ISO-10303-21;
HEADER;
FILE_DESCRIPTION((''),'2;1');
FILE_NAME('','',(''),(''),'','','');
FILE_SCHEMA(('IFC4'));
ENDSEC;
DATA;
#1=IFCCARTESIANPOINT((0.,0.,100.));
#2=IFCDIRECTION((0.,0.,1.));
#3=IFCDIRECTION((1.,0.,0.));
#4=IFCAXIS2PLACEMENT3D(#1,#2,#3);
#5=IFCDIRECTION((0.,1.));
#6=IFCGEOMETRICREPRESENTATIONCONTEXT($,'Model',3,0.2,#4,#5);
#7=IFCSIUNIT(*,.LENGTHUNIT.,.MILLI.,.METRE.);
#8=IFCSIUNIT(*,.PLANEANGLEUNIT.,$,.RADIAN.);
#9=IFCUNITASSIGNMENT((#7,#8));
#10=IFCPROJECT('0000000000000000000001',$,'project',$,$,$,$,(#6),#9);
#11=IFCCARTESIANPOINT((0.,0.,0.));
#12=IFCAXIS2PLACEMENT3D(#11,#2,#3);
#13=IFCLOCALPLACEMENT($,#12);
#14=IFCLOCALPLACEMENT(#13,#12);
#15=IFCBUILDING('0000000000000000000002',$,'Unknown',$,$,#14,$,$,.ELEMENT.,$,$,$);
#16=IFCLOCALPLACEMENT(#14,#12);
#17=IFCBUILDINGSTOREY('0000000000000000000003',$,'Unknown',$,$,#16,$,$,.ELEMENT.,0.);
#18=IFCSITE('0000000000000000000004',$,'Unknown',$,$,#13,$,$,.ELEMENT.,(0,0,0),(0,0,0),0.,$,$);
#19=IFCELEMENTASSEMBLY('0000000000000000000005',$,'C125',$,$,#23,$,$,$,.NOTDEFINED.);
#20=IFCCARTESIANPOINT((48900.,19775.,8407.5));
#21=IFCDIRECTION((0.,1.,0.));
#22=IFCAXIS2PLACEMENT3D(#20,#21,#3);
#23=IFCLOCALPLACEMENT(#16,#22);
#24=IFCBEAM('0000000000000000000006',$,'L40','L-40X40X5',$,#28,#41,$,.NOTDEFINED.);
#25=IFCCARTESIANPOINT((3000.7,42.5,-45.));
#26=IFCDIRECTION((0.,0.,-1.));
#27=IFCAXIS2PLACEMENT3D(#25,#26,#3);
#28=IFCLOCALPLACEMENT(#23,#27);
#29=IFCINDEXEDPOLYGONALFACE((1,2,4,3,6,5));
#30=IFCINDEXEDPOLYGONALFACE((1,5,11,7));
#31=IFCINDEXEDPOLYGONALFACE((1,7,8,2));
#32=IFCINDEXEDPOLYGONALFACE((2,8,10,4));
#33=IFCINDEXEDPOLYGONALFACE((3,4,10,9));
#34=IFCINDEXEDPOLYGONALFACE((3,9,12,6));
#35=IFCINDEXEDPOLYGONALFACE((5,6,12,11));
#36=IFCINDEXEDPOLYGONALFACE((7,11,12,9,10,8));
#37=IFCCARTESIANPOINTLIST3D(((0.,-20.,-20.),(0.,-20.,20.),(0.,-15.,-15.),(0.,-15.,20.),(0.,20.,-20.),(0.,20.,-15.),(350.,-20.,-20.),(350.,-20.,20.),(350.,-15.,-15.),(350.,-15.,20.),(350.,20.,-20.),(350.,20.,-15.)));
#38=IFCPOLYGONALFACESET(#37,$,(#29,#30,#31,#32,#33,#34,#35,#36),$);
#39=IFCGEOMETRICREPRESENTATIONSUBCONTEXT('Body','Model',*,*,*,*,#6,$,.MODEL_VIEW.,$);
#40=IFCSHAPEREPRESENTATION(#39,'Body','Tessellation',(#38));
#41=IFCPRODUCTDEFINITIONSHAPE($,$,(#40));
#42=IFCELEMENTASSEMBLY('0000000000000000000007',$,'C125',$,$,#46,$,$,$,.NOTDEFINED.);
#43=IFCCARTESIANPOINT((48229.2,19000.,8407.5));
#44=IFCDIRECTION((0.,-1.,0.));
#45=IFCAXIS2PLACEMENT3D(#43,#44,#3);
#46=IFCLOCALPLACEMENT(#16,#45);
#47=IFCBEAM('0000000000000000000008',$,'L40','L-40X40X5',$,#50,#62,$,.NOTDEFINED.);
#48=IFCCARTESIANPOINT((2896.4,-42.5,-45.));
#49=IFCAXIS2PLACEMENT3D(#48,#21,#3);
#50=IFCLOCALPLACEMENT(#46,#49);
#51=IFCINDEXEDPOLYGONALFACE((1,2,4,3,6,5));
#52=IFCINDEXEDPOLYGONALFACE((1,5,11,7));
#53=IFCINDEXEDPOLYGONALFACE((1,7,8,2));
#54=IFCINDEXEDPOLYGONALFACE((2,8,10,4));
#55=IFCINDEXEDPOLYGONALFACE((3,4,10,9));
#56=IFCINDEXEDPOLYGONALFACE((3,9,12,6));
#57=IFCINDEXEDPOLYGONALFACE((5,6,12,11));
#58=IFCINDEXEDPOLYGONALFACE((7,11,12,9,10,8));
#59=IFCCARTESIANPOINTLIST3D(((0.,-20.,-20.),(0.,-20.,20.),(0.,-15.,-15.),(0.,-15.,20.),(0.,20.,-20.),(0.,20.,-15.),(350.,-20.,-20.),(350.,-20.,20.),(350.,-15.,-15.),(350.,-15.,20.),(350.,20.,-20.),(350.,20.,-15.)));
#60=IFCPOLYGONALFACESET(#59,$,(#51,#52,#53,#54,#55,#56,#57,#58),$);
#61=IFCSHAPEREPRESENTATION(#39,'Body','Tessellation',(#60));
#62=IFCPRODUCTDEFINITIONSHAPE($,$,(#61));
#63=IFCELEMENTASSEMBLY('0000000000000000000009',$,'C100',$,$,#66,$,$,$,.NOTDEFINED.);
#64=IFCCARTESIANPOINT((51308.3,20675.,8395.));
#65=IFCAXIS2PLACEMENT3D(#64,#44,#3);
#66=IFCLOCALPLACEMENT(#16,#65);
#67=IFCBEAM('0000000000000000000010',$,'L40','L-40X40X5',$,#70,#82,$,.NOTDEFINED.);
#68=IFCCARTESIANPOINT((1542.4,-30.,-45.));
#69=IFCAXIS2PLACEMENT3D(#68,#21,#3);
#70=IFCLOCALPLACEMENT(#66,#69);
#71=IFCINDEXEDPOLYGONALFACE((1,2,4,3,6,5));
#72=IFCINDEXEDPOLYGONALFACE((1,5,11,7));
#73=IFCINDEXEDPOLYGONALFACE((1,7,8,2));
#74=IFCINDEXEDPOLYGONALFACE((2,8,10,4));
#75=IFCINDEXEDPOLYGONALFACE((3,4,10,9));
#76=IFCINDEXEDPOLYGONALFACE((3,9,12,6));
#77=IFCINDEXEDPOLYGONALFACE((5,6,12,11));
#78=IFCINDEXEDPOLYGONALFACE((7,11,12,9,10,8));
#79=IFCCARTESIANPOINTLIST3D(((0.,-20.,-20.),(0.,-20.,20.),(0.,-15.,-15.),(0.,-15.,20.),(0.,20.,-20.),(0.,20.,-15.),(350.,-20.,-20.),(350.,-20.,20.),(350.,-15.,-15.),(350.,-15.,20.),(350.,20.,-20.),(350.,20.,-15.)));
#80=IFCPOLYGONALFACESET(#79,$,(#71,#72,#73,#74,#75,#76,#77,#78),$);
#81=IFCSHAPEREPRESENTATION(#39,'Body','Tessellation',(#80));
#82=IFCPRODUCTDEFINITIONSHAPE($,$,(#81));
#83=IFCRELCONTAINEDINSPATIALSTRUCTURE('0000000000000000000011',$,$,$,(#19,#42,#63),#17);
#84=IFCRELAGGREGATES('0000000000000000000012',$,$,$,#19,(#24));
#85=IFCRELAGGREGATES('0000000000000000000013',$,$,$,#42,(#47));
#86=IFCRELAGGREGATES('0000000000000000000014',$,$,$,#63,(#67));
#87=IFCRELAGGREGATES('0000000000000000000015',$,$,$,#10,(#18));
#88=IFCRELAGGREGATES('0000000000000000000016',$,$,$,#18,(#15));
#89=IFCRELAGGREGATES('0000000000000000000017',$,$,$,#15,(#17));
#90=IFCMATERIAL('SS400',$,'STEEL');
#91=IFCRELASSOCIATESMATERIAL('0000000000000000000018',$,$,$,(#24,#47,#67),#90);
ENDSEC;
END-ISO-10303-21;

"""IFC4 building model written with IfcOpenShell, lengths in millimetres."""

from ifc_helpers import new_model, si_unit, direction, frame, origin_with_axes, place, context, subcontext, project, spatial, line, indexed_curve, outline, extrude, material, element, aggregate, save


model = new_model("IFC4")

# Units and contexts
model_context = context("Model", 3, precision=0.2, world=frame((0.0, 0.0, 100.0), z_axis=(0.0, 0.0, 1.0), x_axis=(1.0, 0.0, 0.0)), true_north=direction((0.0, 1.0)))
body_context = subcontext(model_context, "Body", "Model", "MODEL_VIEW")
ifc_project = project(units=[si_unit("LENGTHUNIT", "METRE", prefix="MILLI"), si_unit("PLANEANGLEUNIT", "RADIAN")], contexts=[model_context])

# Site, building, storey
site_placement = place(None, origin_with_axes())
site = spatial("IfcSite", under=ifc_project, at=site_placement, Name="Unknown", CompositionType="ELEMENT", RefLatitude=(0, 0, 0), RefLongitude=(0, 0, 0), RefElevation=0.0)
building_placement = place(site_placement, origin_with_axes())
building = spatial("IfcBuilding", under=site, at=building_placement, Name="Unknown", CompositionType="ELEMENT")
storey_placement = place(building_placement, origin_with_axes())
storey = spatial("IfcBuildingStorey", under=building, at=storey_placement, Name="Unknown", CompositionType="ELEMENT", Elevation=0.0)

# Shared definitions
ifc_material_1 = material(Name="SS400", Category="STEEL")

# Element assemblies, beams
assembly_1_placement = place(storey_placement, frame((48900.0, 19775.0, 8407.5), z_axis=(0.0, 1.0, 0.0), x_axis=(1.0, 0.0, 0.0)))
assembly_1 = element("IfcElementAssembly", 1, at=assembly_1_placement, inside=storey, Name="C125", PredefinedType="NOTDEFINED")
beam_1_placement = place(assembly_1_placement, frame((3000.7, 42.5, -45.0), z_axis=(0.0, 0.0, -1.0), x_axis=(1.0, 0.0, 0.0)))
beam_1 = element("IfcBeam", 2, at=beam_1_placement, material=ifc_material_1, Name="L40", Description="L-40X40X5", PredefinedType="NOTDEFINED", context=body_context, shape_type="SolidModel", body=[
    extrude(outline(indexed_curve([(-20.0, -20.0), (20.0, -20.0), (20.0, -15.0), (-15.0, -15.0), (-15.0, 20.0), (-20.0, 20.0)], segments=[line(1, 2, 3, 4, 5, 6, 1)])), frame((0.0, 0.0, 0.0), z_axis=(-1.0, 0.0, 0.0), x_axis=(0.0, 0.0, 1.0)), (0.0, 0.0, -1.0), 350.0),
])
aggregate(assembly_1, [beam_1])
assembly_2_placement = place(storey_placement, frame((48229.2, 19000.0, 8407.5), z_axis=(0.0, -1.0, 0.0), x_axis=(1.0, 0.0, 0.0)))
assembly_2 = element("IfcElementAssembly", 3, at=assembly_2_placement, inside=storey, Name="C125", PredefinedType="NOTDEFINED")
beam_2_placement = place(assembly_2_placement, frame((2896.4, -42.5, -45.0), z_axis=(0.0, 1.0, 0.0), x_axis=(1.0, 0.0, 0.0)))
beam_2 = element("IfcBeam", 4, at=beam_2_placement, material=ifc_material_1, Name="L40", Description="L-40X40X5", PredefinedType="NOTDEFINED", context=body_context, shape_type="SolidModel", body=[
    extrude(outline(indexed_curve([(-20.0, -20.0), (20.0, -20.0), (20.0, -15.0), (-15.0, -15.0), (-15.0, 20.0), (-20.0, 20.0)], segments=[line(1, 2, 3, 4, 5, 6, 1)])), frame((0.0, 0.0, 0.0), z_axis=(-1.0, 0.0, 0.0), x_axis=(0.0, 0.0, 1.0)), (0.0, 0.0, -1.0), 350.0),
])
aggregate(assembly_2, [beam_2])
assembly_3_placement = place(storey_placement, frame((51308.3, 20675.0, 8395.0), z_axis=(0.0, -1.0, 0.0), x_axis=(1.0, 0.0, 0.0)))
assembly_3 = element("IfcElementAssembly", 5, at=assembly_3_placement, inside=storey, Name="C100", PredefinedType="NOTDEFINED")
beam_3_placement = place(assembly_3_placement, frame((1542.4, -30.0, -45.0), z_axis=(0.0, 1.0, 0.0), x_axis=(1.0, 0.0, 0.0)))
beam_3 = element("IfcBeam", 6, at=beam_3_placement, material=ifc_material_1, Name="L40", Description="L-40X40X5", PredefinedType="NOTDEFINED", context=body_context, shape_type="SolidModel", body=[
    extrude(outline(indexed_curve([(-20.0, -20.0), (20.0, -20.0), (20.0, -15.0), (-15.0, -15.0), (-15.0, 20.0), (-20.0, 20.0)], segments=[line(1, 2, 3, 4, 5, 6, 1)])), frame((0.0, 0.0, 0.0), z_axis=(-1.0, 0.0, 0.0), x_axis=(0.0, 0.0, 1.0)), (0.0, 0.0, -1.0), 350.0),
])
aggregate(assembly_3, [beam_3])

save(model, "model.ifc")
